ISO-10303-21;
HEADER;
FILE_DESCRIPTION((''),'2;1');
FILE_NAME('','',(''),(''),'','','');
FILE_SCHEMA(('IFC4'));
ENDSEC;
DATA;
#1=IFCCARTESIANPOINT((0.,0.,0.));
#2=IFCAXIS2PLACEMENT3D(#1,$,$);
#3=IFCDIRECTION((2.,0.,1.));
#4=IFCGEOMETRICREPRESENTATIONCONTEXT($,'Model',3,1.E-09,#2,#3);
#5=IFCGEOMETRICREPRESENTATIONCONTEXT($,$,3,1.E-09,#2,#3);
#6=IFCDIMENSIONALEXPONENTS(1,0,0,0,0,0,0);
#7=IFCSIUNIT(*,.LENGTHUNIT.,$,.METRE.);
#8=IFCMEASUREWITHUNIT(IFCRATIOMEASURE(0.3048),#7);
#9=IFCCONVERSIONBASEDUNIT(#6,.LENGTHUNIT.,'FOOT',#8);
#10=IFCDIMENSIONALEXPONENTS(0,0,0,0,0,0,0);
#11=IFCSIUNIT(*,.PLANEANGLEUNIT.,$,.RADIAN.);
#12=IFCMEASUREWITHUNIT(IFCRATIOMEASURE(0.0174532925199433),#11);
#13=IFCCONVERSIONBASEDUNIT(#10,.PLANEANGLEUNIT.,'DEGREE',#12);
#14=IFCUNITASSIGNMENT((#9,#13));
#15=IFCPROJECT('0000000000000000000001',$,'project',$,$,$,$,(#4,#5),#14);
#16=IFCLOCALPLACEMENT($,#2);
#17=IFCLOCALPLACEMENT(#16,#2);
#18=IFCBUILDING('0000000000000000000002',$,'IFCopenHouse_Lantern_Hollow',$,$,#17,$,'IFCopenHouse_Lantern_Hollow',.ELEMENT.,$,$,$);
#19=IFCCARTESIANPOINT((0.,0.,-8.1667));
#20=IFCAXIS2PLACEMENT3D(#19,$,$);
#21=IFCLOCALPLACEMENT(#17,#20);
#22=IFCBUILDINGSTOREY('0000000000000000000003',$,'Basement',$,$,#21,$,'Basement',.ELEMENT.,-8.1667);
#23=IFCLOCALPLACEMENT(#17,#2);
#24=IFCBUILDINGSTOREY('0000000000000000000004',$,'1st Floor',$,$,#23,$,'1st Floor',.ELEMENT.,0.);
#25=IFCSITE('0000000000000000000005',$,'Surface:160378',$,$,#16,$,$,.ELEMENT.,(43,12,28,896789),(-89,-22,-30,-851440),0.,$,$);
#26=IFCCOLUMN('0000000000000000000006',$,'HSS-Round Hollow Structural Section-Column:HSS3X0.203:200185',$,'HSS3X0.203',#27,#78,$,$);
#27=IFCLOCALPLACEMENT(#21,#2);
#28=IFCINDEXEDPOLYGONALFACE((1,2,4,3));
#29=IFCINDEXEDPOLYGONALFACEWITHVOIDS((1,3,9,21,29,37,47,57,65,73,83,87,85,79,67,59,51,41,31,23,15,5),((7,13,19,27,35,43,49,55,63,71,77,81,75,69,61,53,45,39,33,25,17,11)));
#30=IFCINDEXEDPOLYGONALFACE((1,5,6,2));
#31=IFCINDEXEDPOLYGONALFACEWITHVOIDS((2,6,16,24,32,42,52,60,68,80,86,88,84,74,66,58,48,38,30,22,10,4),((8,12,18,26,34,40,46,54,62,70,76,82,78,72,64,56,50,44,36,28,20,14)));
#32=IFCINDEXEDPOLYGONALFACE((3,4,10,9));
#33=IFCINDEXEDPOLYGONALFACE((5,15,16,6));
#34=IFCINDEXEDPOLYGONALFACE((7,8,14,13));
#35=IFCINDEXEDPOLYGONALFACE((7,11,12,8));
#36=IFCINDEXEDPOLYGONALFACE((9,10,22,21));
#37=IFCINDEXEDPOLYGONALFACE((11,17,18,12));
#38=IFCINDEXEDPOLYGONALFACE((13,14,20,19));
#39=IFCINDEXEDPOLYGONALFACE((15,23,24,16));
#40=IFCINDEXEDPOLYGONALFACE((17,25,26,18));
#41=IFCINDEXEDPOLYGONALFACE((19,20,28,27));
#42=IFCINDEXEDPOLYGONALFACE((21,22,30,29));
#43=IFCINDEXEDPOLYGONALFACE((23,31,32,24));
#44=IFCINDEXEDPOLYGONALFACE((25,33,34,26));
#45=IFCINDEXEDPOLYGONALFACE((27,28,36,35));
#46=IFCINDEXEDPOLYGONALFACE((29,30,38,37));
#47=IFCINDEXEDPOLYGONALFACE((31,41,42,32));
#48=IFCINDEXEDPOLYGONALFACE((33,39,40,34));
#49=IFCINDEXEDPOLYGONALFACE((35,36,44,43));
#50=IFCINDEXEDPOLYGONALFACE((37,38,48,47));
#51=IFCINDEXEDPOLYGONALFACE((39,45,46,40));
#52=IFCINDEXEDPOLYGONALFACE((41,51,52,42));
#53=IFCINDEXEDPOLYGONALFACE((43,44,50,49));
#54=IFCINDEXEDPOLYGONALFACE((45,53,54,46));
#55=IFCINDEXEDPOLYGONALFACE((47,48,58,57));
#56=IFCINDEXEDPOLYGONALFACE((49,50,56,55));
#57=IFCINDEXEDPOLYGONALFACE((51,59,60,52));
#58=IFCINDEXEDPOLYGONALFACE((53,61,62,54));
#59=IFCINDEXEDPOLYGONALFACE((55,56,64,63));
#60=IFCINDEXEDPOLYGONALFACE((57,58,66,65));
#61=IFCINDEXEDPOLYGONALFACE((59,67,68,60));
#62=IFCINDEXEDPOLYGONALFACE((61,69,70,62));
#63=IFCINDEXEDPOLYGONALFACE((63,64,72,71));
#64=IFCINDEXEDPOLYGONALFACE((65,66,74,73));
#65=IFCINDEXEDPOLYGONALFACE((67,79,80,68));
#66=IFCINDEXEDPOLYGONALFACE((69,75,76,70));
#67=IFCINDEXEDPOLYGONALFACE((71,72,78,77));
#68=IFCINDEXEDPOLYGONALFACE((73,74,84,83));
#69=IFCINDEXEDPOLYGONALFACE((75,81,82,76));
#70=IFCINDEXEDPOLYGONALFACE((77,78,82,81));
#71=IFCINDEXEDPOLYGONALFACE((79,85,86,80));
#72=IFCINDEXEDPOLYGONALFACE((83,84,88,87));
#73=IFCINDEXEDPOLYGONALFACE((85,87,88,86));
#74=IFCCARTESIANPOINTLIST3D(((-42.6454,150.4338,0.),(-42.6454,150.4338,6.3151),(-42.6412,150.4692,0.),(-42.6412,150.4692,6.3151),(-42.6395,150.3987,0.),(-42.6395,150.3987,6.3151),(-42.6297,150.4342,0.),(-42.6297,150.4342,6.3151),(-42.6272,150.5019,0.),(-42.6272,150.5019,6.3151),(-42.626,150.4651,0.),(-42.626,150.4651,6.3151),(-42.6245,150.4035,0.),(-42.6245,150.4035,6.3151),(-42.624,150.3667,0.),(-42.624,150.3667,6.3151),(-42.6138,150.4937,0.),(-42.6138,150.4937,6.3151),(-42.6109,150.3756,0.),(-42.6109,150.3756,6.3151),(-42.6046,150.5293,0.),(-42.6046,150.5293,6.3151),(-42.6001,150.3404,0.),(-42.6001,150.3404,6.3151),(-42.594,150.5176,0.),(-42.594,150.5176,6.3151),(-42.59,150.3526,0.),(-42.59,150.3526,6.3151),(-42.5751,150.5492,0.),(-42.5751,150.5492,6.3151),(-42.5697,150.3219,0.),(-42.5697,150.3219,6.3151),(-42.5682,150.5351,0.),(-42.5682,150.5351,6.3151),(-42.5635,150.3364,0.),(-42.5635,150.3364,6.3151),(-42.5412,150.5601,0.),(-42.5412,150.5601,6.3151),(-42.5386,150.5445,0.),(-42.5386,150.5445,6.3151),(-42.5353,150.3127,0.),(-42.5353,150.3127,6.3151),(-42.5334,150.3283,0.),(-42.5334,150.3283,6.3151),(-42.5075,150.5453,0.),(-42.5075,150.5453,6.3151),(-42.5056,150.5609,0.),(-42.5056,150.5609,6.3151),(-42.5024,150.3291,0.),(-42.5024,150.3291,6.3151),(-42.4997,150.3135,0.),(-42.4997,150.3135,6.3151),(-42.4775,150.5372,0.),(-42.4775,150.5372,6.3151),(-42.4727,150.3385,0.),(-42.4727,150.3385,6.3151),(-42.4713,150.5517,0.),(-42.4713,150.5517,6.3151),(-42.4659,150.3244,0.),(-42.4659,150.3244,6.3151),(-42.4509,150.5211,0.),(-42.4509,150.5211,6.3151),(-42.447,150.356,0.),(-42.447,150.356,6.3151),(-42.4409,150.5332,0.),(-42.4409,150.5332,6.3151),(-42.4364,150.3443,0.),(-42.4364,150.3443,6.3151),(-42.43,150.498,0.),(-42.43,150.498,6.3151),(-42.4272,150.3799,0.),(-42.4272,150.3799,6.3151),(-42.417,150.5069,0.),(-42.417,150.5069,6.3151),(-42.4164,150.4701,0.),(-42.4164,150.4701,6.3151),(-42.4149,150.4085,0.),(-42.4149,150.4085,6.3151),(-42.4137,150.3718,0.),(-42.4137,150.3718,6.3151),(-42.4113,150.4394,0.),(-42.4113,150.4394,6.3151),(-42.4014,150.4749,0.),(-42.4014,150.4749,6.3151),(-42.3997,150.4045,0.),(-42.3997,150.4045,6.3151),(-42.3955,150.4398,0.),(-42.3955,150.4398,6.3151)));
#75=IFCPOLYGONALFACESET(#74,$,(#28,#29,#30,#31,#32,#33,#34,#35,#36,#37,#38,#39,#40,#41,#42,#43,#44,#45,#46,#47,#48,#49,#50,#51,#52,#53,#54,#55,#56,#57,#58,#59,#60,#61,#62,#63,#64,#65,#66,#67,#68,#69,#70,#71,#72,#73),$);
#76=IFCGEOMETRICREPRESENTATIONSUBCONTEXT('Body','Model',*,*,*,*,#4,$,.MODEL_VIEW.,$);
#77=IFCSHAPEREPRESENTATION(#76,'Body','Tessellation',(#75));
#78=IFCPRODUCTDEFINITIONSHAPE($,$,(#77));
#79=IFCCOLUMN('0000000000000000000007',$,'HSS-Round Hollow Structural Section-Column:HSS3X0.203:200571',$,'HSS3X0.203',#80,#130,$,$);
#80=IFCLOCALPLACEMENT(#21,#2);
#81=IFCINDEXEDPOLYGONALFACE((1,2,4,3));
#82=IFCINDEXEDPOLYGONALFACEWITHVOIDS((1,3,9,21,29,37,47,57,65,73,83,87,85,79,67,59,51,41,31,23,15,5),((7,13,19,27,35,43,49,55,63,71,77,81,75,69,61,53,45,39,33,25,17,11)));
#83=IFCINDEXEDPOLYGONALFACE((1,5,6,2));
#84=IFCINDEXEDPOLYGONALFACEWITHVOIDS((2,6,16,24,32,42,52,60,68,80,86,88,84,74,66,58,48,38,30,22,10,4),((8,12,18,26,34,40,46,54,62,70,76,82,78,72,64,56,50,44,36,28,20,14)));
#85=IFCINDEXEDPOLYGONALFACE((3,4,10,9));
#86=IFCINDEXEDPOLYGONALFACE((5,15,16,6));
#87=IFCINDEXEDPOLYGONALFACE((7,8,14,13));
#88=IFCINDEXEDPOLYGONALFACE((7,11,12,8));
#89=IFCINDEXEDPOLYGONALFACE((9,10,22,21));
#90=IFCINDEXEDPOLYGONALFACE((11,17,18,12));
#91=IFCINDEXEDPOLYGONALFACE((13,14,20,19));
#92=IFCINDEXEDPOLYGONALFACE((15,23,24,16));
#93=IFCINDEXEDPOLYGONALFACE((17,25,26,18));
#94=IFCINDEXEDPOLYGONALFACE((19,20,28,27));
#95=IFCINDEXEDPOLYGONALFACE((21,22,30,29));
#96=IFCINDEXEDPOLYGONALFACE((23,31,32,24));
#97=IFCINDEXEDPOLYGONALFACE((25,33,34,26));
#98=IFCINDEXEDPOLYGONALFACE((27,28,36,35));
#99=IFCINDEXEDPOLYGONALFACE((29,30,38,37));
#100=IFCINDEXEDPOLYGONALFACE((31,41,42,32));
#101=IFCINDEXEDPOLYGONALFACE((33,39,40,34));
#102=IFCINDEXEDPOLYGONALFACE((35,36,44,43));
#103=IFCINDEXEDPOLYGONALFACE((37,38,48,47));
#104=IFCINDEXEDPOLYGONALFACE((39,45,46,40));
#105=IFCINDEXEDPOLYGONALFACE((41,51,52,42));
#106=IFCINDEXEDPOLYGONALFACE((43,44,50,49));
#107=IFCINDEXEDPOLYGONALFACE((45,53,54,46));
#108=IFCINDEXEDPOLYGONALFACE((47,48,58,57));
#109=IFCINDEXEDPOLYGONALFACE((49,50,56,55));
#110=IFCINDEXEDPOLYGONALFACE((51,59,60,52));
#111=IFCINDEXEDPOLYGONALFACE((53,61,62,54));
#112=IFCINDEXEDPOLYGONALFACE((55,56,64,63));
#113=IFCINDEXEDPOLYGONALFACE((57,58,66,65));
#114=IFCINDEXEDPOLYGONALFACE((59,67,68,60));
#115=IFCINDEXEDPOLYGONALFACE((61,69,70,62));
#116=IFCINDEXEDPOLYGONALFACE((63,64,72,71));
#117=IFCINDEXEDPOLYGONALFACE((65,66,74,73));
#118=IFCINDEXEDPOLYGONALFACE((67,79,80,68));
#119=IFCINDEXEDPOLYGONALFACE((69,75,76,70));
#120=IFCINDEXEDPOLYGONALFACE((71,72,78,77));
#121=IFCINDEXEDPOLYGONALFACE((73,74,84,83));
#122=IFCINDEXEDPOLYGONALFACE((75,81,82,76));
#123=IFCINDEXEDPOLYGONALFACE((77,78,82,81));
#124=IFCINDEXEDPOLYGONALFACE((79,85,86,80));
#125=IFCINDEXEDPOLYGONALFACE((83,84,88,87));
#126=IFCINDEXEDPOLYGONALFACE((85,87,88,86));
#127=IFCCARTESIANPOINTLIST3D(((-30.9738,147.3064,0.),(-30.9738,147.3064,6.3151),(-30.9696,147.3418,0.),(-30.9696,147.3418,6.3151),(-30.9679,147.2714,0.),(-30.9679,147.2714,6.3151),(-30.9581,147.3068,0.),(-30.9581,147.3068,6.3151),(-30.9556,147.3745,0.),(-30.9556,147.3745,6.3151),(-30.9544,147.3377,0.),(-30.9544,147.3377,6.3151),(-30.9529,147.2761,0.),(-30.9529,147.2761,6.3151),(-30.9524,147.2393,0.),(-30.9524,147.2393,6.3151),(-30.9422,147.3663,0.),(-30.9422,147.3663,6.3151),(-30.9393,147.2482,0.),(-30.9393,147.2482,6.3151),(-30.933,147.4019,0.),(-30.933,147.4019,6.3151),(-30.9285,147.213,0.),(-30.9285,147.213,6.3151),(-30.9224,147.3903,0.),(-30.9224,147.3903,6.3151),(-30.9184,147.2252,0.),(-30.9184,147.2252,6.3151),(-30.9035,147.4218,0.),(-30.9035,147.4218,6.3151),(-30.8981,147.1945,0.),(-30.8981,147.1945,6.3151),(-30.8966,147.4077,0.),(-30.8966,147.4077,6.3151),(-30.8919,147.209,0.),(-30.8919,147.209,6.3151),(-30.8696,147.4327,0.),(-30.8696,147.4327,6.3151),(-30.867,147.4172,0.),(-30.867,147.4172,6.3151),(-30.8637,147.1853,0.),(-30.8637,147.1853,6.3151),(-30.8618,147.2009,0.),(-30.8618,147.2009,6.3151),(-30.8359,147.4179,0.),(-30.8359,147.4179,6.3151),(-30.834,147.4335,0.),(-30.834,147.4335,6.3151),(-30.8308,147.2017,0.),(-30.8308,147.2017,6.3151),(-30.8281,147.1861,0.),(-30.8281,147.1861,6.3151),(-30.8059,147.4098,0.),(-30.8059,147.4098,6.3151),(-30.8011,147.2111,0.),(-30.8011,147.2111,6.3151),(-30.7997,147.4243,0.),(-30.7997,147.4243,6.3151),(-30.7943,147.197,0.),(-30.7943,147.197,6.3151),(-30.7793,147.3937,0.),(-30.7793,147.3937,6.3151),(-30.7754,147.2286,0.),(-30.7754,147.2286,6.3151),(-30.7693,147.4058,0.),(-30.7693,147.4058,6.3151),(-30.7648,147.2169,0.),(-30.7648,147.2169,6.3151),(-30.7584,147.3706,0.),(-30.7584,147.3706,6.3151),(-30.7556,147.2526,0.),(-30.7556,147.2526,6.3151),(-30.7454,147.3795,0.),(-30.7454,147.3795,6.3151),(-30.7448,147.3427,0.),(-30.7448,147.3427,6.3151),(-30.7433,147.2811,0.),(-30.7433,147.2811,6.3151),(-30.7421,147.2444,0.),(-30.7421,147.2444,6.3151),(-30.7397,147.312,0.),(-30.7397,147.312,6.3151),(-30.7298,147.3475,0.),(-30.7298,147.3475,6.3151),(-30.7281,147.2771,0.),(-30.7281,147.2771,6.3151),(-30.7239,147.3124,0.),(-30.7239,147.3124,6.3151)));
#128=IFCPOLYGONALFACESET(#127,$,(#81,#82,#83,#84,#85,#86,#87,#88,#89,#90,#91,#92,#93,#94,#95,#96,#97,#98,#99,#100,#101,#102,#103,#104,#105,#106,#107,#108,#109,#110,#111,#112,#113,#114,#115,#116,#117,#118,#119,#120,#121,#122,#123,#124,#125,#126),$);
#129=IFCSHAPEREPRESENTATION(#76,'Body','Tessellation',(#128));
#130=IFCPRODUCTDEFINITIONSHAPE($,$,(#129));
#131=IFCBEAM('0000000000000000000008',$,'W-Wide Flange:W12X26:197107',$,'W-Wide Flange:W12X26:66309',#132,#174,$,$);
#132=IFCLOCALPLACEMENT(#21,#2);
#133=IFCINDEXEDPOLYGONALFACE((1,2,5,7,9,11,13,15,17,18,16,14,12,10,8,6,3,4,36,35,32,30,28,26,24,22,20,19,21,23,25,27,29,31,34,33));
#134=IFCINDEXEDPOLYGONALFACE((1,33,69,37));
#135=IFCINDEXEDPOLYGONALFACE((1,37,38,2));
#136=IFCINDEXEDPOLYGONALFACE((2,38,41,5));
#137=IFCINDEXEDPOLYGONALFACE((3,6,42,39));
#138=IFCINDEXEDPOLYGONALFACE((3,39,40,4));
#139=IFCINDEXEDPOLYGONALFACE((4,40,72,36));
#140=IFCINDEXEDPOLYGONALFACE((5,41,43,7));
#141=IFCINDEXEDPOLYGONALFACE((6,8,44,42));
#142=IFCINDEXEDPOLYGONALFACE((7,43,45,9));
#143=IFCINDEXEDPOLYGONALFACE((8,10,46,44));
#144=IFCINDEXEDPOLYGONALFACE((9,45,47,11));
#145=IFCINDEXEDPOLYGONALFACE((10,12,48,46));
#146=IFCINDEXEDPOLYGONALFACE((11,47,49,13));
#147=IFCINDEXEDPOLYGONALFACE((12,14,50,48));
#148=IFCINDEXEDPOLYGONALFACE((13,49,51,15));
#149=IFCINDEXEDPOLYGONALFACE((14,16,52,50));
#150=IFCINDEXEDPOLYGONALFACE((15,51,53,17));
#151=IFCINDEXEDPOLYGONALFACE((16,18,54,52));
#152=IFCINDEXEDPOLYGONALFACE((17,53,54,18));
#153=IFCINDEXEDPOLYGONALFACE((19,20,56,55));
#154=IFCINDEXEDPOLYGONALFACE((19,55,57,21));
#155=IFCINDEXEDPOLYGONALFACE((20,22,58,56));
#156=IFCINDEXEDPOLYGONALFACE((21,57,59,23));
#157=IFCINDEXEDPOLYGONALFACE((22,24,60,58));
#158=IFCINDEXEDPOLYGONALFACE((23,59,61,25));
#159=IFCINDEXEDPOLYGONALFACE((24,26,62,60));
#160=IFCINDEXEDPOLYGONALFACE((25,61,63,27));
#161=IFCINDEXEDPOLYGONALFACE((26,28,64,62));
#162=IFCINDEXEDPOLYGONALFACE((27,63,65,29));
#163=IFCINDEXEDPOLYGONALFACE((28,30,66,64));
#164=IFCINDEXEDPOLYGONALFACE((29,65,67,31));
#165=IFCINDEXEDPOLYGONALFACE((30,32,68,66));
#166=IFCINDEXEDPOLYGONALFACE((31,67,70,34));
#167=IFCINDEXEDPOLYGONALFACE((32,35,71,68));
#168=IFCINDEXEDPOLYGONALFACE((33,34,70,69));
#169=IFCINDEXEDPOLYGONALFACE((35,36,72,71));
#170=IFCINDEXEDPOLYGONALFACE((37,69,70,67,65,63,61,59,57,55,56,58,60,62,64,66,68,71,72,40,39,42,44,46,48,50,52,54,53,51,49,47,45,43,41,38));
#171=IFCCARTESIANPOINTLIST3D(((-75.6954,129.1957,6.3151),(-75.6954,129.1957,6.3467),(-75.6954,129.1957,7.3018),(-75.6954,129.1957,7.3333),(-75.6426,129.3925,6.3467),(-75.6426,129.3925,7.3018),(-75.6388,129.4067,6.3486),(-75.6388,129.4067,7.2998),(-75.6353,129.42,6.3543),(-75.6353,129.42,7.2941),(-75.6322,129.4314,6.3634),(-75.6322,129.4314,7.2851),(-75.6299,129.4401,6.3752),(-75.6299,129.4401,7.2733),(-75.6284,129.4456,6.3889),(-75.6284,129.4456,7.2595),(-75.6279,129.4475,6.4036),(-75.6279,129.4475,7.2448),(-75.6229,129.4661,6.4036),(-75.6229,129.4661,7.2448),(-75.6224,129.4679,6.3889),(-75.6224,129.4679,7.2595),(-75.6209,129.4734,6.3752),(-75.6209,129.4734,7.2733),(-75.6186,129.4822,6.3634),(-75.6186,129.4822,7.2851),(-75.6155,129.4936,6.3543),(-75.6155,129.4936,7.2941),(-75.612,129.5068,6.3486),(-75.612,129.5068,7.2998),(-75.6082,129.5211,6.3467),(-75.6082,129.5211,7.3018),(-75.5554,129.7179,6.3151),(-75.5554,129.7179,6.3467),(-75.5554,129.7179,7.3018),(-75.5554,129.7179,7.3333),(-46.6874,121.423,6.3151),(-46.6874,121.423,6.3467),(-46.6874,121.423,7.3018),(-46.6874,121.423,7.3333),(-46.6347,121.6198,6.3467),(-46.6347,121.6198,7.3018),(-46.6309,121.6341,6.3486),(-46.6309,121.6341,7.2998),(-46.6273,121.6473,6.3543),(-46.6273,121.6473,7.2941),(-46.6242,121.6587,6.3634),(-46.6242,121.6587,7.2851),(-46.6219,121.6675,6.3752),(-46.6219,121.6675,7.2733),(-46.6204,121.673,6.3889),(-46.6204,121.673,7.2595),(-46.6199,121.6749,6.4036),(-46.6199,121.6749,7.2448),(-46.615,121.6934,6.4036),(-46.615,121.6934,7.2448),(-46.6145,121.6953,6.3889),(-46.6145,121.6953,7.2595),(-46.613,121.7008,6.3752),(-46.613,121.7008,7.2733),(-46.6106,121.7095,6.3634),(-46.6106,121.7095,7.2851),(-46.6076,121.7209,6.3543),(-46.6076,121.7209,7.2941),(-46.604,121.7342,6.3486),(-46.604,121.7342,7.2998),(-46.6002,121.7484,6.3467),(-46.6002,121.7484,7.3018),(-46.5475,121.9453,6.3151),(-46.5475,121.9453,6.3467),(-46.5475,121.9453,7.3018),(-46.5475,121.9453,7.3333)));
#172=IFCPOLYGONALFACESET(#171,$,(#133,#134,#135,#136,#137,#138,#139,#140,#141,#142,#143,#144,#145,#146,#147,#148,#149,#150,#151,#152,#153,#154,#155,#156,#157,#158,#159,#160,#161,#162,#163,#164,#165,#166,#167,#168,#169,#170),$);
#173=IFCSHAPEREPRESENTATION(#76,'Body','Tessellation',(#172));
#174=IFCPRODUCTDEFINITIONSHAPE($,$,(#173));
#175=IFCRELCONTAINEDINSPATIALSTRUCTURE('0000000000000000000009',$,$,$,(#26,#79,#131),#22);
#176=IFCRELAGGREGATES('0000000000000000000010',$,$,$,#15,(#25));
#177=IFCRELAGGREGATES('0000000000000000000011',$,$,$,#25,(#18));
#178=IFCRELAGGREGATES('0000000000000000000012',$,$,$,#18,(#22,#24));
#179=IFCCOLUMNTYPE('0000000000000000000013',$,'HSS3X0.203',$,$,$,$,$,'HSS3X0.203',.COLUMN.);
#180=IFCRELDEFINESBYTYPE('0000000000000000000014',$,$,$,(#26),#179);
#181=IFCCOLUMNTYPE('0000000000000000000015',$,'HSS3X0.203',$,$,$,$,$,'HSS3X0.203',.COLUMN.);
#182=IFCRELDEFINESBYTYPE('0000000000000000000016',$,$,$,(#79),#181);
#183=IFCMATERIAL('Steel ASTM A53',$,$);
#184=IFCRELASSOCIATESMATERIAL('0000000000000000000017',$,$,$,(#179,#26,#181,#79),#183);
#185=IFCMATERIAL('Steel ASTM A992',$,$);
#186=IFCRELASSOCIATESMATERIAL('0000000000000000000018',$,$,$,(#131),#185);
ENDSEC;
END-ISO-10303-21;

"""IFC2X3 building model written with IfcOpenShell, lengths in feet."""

from ifc_helpers import new_model, entity, si_unit, converted_unit, direction, frame, frame_2d, origin, place, context, subcontext, project, spatial, circle_curve, parameter, trimmed, segment, composite_curve, i_section, outline, extrude, source, transform, mapped, material, type_object, type_shapes, element, save


model = new_model("IFC2X3")

# Units and contexts
model_context = context("Model", 3, precision=1e-09, world=origin(), true_north=direction((2.0, 0.0, 1.0)))
context_of_model = context(None, 3, precision=1e-09, world=origin(), true_north=direction((2.0, 0.0, 1.0)))
body_context = subcontext(model_context, "Body", "Model", "MODEL_VIEW")
ifc_project = project(units=[converted_unit("LENGTHUNIT", "FOOT", entity("IfcRatioMeasure", 0.3048), si_unit("LENGTHUNIT", "METRE"), dimensions=[1, 0, 0, 0, 0, 0, 0]), converted_unit("PLANEANGLEUNIT", "DEGREE", entity("IfcRatioMeasure", 0.0174532925199433), si_unit("PLANEANGLEUNIT", "RADIAN"), dimensions=[0, 0, 0, 0, 0, 0, 0])], contexts=[model_context, context_of_model])

# Site, building, storey
site_placement = place(None, origin())
site = spatial("IfcSite", under=ifc_project, at=site_placement, Name="Surface:160378", CompositionType="ELEMENT", RefLatitude=(43, 12, 28, 896789), RefLongitude=(-89, -22, -30, -851440), RefElevation=0.0)
building_placement = place(site_placement, origin())
building = spatial("IfcBuilding", under=site, at=building_placement, Name="IFCopenHouse_Lantern_Hollow", LongName="IFCopenHouse_Lantern_Hollow", CompositionType="ELEMENT")
storey_1_placement = place(building_placement, frame((0.0, 0.0, -8.1667)))
storey_1 = spatial("IfcBuildingStorey", under=building, at=storey_1_placement, Name="Basement", LongName="Basement", CompositionType="ELEMENT", Elevation=-8.1667)

# Columns
ifc_material_1 = material(Name="Steel ASTM A53")
column_type_1 = type_object("IfcColumnType", Name="HSS3X0.203", ElementType="HSS3X0.203", PredefinedType="COLUMN", material=ifc_material_1)
shared_shape_1 = source(origin(), body_context, "Body", "SweptSolid", [
    extrude(outline(composite_curve([segment(trimmed(circle_curve(frame_2d((-42.5205, 150.4368), x_axis=(0.965926, -0.258819)), 0.125), [parameter(0.0)], [parameter(180.0)], True, "PARAMETER"), True, "CONTINUOUS"), segment(trimmed(circle_curve(frame_2d((-42.5205, 150.4368), x_axis=(0.965926, -0.258819)), 0.125), [parameter(180.0)], [parameter(0.0)], True, "PARAMETER"), True, "CONTINUOUS")], self_intersect=False), holes=[composite_curve([segment(trimmed(circle_curve(frame_2d((-42.5205, 150.4368), x_axis=(0.965926, -0.258819)), 0.1092), [parameter(180.0)], [parameter(0.0)], True, "PARAMETER"), False, "CONTINUOUS"), segment(trimmed(circle_curve(frame_2d((-42.5205, 150.4368), x_axis=(0.965926, -0.258819)), 0.1092), [parameter(0.0)], [parameter(180.0)], True, "PARAMETER"), False, "CONTINUOUS")], self_intersect=False)]), origin(), (0.0, 0.0, 1.0), 6.3151),
])
type_shapes(column_type_1, [shared_shape_1])
column_1_placement = place(storey_1_placement, origin())
element("IfcColumn", 1, at=column_1_placement, inside=storey_1, type_object=column_type_1, material=ifc_material_1, Name="HSS-Round Hollow Structural Section-Column:HSS3X0.203:200185", ObjectType="HSS3X0.203", context=body_context, shape_type="MappedRepresentation", body=[
    mapped(shared_shape_1, transform((0.0, 0.0, 0.0), scale=1.0)),
])
column_type_2 = type_object("IfcColumnType", Name="HSS3X0.203", ElementType="HSS3X0.203", PredefinedType="COLUMN", material=ifc_material_1)
shared_shape_2 = source(origin(), body_context, "Body", "SweptSolid", [
    extrude(outline(composite_curve([segment(trimmed(circle_curve(frame_2d((-30.8489, 147.3094), x_axis=(0.965926, -0.258819)), 0.125), [parameter(0.0)], [parameter(180.0)], True, "PARAMETER"), True, "CONTINUOUS"), segment(trimmed(circle_curve(frame_2d((-30.8489, 147.3094), x_axis=(0.965926, -0.258819)), 0.125), [parameter(180.0)], [parameter(0.0)], True, "PARAMETER"), True, "CONTINUOUS")], self_intersect=False), holes=[composite_curve([segment(trimmed(circle_curve(frame_2d((-30.8489, 147.3094), x_axis=(0.965926, -0.258819)), 0.1092), [parameter(180.0)], [parameter(0.0)], True, "PARAMETER"), False, "CONTINUOUS"), segment(trimmed(circle_curve(frame_2d((-30.8489, 147.3094), x_axis=(0.965926, -0.258819)), 0.1092), [parameter(0.0)], [parameter(180.0)], True, "PARAMETER"), False, "CONTINUOUS")], self_intersect=False)]), origin(), (0.0, 0.0, 1.0), 6.3151),
])
type_shapes(column_type_2, [shared_shape_2])
column_2_placement = place(storey_1_placement, origin())
element("IfcColumn", 2, at=column_2_placement, inside=storey_1, type_object=column_type_2, material=ifc_material_1, Name="HSS-Round Hollow Structural Section-Column:HSS3X0.203:200571", ObjectType="HSS3X0.203", context=body_context, shape_type="MappedRepresentation", body=[
    mapped(shared_shape_2, transform((0.0, 0.0, 0.0), scale=1.0)),
])

# Beam
ifc_material_2 = material(Name="Steel ASTM A992")
beam_placement = place(storey_1_placement, frame((-75.6254, 129.4568, 8.1667), z_axis=(0.0, 0.0, 1.0), x_axis=(0.965926, -0.258819, 0.0)))
element("IfcBeam", 3, at=beam_placement, inside=storey_1, material=ifc_material_2, Name="W-Wide Flange:W12X26:197107", ObjectType="W-Wide Flange:W12X26:66309", context=body_context, shape_type="SweptSolid", body=[
    extrude(i_section(OverallWidth=0.5407, OverallDepth=1.0182, WebThickness=0.0192, FlangeThickness=0.0316, FilletRadius=0.057, at=frame_2d((0.0, 0.0), x_axis=(0.0, 1.0))), frame((0.0, 0.0, -1.3424), z_axis=(1.0, 0.0, 0.0), x_axis=(0.0, 0.0, -1.0)), (0.0, 0.0, 1.0), 30.0313),
])

# Shared definitions
storey_2_placement = place(building_placement, origin())
storey_2 = spatial("IfcBuildingStorey", under=building, at=storey_2_placement, Name="1st Floor", LongName="1st Floor", CompositionType="ELEMENT", Elevation=0.0)

save(model, "model.ifc")
